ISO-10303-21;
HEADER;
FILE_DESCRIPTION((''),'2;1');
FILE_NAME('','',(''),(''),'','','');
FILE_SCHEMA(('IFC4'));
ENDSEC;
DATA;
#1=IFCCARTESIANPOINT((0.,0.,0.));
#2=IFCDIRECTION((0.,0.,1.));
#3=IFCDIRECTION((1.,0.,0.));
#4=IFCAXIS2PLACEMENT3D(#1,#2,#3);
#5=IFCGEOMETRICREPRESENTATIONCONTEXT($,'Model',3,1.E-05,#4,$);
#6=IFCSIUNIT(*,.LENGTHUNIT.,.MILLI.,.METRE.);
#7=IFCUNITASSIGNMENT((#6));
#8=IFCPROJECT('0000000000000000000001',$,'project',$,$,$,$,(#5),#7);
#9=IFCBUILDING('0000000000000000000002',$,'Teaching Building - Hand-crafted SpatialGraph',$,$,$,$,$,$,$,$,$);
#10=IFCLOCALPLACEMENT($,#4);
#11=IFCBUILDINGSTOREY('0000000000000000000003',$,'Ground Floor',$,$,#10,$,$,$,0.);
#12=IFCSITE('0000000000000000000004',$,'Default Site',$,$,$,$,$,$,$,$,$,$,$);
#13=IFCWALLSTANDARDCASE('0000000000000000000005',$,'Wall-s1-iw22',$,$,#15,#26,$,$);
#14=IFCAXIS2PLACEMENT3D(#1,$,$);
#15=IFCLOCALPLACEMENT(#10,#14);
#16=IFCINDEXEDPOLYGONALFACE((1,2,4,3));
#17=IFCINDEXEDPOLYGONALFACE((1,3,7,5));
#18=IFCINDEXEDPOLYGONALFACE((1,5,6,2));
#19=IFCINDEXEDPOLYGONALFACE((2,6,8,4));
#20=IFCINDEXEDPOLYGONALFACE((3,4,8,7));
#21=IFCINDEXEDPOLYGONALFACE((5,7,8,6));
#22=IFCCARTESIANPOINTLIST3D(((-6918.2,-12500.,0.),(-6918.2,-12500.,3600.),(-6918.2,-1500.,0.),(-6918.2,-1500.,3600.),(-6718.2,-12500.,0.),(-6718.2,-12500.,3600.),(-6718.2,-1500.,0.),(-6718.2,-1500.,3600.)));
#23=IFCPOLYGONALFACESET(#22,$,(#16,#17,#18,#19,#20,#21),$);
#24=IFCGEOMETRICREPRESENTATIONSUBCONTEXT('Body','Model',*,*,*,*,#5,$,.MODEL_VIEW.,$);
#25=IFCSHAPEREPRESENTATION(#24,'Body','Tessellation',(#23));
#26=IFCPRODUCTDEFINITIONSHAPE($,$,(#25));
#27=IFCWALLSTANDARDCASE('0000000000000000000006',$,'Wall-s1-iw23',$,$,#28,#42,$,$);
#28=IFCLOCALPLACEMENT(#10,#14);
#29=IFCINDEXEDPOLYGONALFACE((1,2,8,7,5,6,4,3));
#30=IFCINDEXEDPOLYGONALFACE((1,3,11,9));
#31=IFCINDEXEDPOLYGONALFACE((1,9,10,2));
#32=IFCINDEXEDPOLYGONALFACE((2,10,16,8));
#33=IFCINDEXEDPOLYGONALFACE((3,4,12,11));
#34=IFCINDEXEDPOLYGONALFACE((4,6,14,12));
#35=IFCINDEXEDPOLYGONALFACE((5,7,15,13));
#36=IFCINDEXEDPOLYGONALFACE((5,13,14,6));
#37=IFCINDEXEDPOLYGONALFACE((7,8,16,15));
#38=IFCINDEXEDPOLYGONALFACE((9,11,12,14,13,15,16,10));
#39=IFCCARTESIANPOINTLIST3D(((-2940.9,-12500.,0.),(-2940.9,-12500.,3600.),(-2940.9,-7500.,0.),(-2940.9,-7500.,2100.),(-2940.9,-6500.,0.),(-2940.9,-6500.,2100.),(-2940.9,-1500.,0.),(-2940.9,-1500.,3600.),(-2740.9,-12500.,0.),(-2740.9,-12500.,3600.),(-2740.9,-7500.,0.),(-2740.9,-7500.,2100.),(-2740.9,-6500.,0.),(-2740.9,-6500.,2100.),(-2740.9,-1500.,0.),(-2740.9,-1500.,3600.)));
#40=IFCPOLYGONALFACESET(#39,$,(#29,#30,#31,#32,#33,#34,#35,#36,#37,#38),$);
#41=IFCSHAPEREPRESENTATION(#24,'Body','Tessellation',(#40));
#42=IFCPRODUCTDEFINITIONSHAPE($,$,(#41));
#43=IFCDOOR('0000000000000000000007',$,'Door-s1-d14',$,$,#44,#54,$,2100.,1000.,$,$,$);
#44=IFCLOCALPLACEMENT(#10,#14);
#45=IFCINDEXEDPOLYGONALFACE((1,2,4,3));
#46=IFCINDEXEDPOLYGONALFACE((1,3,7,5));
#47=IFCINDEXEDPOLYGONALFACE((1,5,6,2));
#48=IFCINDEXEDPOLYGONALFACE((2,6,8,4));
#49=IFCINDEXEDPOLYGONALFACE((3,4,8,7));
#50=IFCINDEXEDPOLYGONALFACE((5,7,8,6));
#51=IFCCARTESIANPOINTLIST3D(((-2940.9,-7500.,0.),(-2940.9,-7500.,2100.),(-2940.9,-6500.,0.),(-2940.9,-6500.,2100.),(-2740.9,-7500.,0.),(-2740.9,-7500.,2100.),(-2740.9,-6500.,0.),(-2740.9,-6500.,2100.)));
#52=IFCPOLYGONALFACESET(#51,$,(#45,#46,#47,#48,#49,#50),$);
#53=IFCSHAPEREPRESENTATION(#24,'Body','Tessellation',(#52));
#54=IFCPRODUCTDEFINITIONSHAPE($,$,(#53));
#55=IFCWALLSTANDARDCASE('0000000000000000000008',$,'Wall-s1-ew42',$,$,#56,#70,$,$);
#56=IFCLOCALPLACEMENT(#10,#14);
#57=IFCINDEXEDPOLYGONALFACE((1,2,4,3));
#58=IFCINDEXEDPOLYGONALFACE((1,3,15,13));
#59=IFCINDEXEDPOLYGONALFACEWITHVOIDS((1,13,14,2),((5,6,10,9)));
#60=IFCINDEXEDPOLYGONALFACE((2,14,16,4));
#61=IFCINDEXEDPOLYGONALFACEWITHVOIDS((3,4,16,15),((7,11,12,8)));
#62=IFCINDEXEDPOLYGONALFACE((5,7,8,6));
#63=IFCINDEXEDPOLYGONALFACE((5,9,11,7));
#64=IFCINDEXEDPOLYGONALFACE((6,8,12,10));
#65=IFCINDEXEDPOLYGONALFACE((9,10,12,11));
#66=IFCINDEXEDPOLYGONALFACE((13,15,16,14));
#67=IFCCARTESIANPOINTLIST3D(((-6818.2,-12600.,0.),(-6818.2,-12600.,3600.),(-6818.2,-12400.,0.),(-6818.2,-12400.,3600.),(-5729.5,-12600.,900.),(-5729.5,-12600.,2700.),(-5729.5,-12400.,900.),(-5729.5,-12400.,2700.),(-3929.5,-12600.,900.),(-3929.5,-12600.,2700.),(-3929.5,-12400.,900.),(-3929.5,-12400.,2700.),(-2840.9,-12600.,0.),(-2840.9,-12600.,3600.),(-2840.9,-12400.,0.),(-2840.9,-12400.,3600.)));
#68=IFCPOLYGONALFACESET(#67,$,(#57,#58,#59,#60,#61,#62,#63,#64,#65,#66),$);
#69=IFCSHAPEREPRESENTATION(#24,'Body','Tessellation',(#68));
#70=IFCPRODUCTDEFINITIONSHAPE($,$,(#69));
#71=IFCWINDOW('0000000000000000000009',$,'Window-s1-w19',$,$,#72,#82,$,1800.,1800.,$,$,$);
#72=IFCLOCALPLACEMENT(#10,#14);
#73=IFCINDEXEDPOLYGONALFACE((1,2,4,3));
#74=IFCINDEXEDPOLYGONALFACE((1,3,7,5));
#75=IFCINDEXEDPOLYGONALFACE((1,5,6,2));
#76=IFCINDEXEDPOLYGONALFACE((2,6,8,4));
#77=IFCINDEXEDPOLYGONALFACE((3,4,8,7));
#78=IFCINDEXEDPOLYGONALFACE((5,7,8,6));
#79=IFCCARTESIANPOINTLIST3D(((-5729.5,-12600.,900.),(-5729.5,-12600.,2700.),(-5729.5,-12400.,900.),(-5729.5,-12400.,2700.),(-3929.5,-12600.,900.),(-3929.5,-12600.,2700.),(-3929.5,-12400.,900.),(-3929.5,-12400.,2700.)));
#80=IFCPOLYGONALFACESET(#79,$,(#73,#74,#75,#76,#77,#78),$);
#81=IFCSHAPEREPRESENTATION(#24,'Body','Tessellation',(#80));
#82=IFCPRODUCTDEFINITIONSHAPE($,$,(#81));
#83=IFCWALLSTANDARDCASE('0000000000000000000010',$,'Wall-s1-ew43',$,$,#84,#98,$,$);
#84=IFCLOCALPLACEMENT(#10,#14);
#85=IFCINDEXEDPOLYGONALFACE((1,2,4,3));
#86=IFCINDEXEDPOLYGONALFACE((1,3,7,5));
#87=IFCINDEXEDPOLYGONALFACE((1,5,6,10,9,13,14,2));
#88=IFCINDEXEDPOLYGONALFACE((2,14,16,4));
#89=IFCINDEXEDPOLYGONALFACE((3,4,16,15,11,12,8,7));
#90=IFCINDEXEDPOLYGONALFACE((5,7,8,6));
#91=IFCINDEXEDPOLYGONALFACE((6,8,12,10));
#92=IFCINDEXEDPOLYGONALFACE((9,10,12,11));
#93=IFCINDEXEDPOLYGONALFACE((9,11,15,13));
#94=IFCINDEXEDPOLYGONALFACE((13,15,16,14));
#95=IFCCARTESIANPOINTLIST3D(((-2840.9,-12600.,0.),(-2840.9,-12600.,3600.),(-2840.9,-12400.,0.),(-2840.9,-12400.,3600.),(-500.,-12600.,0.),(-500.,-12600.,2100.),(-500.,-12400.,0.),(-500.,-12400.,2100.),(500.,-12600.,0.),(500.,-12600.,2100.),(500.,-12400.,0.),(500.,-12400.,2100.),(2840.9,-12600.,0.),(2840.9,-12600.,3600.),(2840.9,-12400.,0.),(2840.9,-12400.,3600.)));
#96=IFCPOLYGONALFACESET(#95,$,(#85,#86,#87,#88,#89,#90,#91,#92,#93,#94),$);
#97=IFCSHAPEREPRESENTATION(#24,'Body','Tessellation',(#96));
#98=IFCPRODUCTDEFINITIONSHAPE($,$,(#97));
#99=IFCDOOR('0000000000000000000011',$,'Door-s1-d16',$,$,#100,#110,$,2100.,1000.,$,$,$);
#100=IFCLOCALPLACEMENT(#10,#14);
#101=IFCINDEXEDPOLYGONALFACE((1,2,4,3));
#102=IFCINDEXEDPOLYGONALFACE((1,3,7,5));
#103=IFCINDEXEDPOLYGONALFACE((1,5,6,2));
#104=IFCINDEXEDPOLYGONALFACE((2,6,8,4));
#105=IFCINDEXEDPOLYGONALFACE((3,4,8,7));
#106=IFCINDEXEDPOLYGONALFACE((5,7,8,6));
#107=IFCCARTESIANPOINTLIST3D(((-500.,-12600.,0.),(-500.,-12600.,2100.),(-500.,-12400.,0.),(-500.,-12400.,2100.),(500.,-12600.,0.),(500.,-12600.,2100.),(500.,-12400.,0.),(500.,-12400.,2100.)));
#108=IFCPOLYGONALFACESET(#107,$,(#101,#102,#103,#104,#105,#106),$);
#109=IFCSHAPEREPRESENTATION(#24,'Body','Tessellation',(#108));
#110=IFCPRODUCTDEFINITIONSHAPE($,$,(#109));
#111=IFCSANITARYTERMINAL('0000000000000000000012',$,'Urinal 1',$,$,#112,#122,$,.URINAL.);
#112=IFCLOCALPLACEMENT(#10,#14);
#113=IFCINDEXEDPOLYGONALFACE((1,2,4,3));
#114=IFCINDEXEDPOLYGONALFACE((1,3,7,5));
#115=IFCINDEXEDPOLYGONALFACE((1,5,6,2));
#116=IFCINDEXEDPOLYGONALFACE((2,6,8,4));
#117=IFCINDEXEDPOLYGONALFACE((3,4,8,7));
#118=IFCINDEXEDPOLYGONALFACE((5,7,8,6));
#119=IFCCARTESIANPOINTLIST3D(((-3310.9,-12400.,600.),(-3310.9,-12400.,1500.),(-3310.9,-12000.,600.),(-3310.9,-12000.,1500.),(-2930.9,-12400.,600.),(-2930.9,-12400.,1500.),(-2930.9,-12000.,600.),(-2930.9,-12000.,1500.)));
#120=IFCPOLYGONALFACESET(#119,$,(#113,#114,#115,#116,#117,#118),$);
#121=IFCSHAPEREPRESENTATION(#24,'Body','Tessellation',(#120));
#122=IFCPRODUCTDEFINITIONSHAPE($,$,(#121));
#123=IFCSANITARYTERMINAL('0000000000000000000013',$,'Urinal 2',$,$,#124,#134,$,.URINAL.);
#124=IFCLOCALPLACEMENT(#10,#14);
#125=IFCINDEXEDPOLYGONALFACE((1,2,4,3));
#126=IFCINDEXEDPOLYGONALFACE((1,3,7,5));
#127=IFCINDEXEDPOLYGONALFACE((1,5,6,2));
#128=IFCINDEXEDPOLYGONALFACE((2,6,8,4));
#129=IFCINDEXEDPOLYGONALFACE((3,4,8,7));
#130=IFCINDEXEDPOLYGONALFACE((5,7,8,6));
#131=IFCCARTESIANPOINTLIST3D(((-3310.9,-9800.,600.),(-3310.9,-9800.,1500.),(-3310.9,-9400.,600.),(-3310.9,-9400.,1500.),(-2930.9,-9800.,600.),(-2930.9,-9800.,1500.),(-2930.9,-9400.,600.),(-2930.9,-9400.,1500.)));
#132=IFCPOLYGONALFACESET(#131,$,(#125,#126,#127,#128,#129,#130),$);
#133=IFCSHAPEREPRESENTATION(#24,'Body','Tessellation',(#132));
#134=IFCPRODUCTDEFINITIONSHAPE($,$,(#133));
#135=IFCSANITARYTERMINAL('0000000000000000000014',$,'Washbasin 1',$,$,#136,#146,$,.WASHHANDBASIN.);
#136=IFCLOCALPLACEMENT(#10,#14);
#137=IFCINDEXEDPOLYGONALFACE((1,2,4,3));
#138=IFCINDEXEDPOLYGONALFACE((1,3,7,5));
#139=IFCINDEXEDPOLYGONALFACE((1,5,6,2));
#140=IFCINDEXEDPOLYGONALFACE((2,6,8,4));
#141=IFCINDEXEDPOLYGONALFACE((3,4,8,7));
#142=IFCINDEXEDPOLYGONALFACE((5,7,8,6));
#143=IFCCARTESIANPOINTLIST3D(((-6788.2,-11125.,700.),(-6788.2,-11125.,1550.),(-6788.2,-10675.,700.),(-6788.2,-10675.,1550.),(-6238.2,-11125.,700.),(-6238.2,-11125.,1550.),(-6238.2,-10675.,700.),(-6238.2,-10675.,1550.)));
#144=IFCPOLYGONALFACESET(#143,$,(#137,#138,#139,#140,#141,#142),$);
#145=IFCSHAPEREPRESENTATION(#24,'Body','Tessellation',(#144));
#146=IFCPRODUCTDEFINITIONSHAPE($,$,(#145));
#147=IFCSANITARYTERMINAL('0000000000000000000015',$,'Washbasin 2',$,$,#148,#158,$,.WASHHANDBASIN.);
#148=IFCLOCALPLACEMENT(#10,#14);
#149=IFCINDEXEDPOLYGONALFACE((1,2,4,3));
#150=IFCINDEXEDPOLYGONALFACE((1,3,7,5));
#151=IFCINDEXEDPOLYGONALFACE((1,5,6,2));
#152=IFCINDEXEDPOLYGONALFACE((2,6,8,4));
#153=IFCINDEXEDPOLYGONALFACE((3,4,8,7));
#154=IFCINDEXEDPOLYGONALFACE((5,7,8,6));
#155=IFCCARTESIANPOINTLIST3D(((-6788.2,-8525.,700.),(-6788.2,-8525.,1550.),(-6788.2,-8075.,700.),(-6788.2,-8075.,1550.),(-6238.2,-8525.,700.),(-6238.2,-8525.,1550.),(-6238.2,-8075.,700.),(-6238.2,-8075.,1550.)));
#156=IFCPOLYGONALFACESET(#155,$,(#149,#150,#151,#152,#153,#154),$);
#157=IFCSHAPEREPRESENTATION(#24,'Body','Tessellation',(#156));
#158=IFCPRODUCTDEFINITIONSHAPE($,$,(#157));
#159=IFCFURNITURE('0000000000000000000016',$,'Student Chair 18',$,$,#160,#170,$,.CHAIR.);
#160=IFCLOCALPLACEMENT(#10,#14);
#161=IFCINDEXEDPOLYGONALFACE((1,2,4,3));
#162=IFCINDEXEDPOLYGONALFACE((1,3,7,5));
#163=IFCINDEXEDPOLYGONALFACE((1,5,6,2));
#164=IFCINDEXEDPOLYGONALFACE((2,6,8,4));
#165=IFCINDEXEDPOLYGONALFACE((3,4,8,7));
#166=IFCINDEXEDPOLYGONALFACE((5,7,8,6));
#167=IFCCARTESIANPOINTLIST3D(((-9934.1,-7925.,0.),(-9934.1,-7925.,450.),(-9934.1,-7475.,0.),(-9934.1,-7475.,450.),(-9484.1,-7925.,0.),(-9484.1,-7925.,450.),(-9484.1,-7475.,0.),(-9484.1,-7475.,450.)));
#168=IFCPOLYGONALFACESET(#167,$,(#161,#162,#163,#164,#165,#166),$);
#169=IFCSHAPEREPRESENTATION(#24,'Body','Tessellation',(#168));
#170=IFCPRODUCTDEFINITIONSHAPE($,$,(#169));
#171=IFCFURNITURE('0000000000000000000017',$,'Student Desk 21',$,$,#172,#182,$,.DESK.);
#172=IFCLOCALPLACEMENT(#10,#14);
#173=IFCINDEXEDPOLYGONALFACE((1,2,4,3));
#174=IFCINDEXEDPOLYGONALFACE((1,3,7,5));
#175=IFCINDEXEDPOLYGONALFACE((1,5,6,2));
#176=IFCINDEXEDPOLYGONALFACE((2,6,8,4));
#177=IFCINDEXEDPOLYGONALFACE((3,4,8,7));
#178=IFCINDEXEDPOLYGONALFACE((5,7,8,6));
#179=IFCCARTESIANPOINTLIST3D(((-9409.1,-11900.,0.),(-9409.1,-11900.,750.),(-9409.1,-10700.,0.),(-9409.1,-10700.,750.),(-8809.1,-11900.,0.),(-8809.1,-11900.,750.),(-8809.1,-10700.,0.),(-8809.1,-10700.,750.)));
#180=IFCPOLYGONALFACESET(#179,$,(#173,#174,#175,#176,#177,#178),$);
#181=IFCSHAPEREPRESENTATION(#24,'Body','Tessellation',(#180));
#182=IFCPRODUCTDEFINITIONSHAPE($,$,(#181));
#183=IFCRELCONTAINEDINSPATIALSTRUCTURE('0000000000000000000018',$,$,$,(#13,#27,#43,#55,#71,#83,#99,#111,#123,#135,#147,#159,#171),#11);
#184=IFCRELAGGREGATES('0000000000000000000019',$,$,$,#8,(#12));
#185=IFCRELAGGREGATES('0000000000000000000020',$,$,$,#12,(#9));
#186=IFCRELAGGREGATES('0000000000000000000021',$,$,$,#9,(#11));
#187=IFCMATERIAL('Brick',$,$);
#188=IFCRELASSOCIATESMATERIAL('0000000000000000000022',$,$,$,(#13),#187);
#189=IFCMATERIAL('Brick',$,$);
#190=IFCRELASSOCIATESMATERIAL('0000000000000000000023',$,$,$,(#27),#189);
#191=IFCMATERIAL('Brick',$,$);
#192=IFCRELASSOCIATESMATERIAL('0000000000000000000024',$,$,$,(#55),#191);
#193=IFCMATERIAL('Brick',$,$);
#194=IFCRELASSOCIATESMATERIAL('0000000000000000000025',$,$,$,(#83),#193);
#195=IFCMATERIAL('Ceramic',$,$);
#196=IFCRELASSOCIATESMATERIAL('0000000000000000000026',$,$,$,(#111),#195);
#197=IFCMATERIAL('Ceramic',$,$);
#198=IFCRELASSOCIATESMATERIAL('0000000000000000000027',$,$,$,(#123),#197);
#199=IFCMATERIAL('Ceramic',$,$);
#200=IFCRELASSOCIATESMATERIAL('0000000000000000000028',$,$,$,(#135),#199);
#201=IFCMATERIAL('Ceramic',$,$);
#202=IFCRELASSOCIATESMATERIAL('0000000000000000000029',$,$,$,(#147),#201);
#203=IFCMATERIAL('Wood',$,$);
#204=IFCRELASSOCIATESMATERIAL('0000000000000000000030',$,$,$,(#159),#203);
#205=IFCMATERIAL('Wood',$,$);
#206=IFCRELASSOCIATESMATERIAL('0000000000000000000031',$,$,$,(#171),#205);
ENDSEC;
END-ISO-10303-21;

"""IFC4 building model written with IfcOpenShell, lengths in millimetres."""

from ifc_helpers import new_model, si_unit, frame, frame_2d, origin_with_axes, origin_2d, place, context, subcontext, project, spatial, rectangle, extrude, material, element, fill, save


model = new_model("IFC4")

# Units and contexts
model_context = context("Model", 3, precision=1e-05, world=origin_with_axes())
body_context = subcontext(model_context, "Body", "Model", "MODEL_VIEW")
ifc_project = project(units=[si_unit("LENGTHUNIT", "METRE", prefix="MILLI")], contexts=[model_context])

# Site, building, storey
site = spatial("IfcSite", under=ifc_project, Name="Default Site")
building = spatial("IfcBuilding", under=site, Name="Teaching Building - Hand-crafted SpatialGraph")
storey_placement = place(None, origin_with_axes())
storey = spatial("IfcBuildingStorey", under=building, at=storey_placement, Name="Ground Floor", Elevation=0.0)

# Wall
ifc_material_1 = material(Name="Brick")
wall_1_placement = place(storey_placement, frame((-6818.2, -12500.0, 0.0), z_axis=(0.0, 0.0, 1.0), x_axis=(0.0, 1.0, 0.0)))
element("IfcWallStandardCase", 1, at=wall_1_placement, inside=storey, material=ifc_material_1, Name="Wall-s1-iw22", context=body_context, shape_type="SweptSolid", body=[
    extrude(rectangle(XDim=11000.0, YDim=200.0, at=frame_2d((5500.0, 0.0))), origin_with_axes(), (0.0, 0.0, 1.0), 3600.0),
])

# Wall, opening, door
ifc_material_2 = material(Name="Brick")
wall_2_placement = place(storey_placement, frame((-2840.9, -12500.0, 0.0), z_axis=(0.0, 0.0, 1.0), x_axis=(0.0, 1.0, 0.0)))
wall_2 = element("IfcWallStandardCase", 2, at=wall_2_placement, inside=storey, material=ifc_material_2, Name="Wall-s1-iw23", context=body_context, shape_type="SweptSolid", body=[
    extrude(rectangle(XDim=11000.0, YDim=200.0, at=frame_2d((5500.0, 0.0))), origin_with_axes(), (0.0, 0.0, 1.0), 3600.0),
])
opening_1_placement = place(wall_2_placement, frame((5000.0, 0.0, 0.0), z_axis=(0.0, 0.0, 1.0), x_axis=(1.0, 0.0, 0.0)))
opening_1 = element("IfcOpeningElement", 3, at=opening_1_placement, cuts=wall_2, context=body_context, shape_type="SweptSolid", body=[
    extrude(rectangle(XDim=1000.0, YDim=400.0, at=frame_2d((500.0, 0.0))), origin_with_axes(), (0.0, 0.0, 1.0), 2100.0),
])
door_1_placement = place(storey_placement, frame((-2840.9, -7500.0, 0.0), z_axis=(0.0, 0.0, 1.0), x_axis=(0.0, 1.0, 0.0)))
door_1 = element("IfcDoor", 4, at=door_1_placement, inside=storey, Name="Door-s1-d14", OverallHeight=2100.0, OverallWidth=1000.0, context=body_context, shape_type="SweptSolid", body=[
    extrude(rectangle(XDim=1000.0, YDim=200.0, at=frame_2d((500.0, 0.0))), origin_with_axes(), (0.0, 0.0, 1.0), 2100.0),
])
fill(opening_1, door_1)

# Wall, opening, window
ifc_material_3 = material(Name="Brick")
wall_3_placement = place(storey_placement, frame((-6818.2, -12500.0, 0.0), z_axis=(0.0, 0.0, 1.0), x_axis=(1.0, 0.0, 0.0)))
wall_3 = element("IfcWallStandardCase", 5, at=wall_3_placement, inside=storey, material=ifc_material_3, Name="Wall-s1-ew42", context=body_context, shape_type="SweptSolid", body=[
    extrude(rectangle(XDim=3977.3, YDim=200.0, at=frame_2d((1988.6, 0.0))), origin_with_axes(), (0.0, 0.0, 1.0), 3600.0),
])
opening_2_placement = place(wall_3_placement, frame((1088.6, 0.0, 900.0), z_axis=(0.0, 0.0, 1.0), x_axis=(1.0, 0.0, 0.0)))
opening_2 = element("IfcOpeningElement", 6, at=opening_2_placement, cuts=wall_3, context=body_context, shape_type="SweptSolid", body=[
    extrude(rectangle(XDim=1800.0, YDim=400.0, at=frame_2d((900.0, 0.0))), origin_with_axes(), (0.0, 0.0, 1.0), 1800.0),
])
window_placement = place(storey_placement, frame((-5729.5, -12500.0, 900.0), z_axis=(0.0, 0.0, 1.0), x_axis=(1.0, 0.0, 0.0)))
window = element("IfcWindow", 7, at=window_placement, inside=storey, Name="Window-s1-w19", OverallHeight=1800.0, OverallWidth=1800.0, context=body_context, shape_type="SweptSolid", body=[
    extrude(rectangle(XDim=1800.0, YDim=200.0, at=frame_2d((900.0, 0.0))), origin_with_axes(), (0.0, 0.0, 1.0), 1800.0),
])
fill(opening_2, window)

# Wall, opening, door
ifc_material_4 = material(Name="Brick")
wall_4_placement = place(storey_placement, frame((-2840.9, -12500.0, 0.0), z_axis=(0.0, 0.0, 1.0), x_axis=(1.0, 0.0, 0.0)))
wall_4 = element("IfcWallStandardCase", 8, at=wall_4_placement, inside=storey, material=ifc_material_4, Name="Wall-s1-ew43", context=body_context, shape_type="SweptSolid", body=[
    extrude(rectangle(XDim=5681.8, YDim=200.0, at=frame_2d((2840.9, 0.0))), origin_with_axes(), (0.0, 0.0, 1.0), 3600.0),
])
opening_3_placement = place(wall_4_placement, frame((2340.9, 0.0, 0.0), z_axis=(0.0, 0.0, 1.0), x_axis=(1.0, 0.0, 0.0)))
opening_3 = element("IfcOpeningElement", 9, at=opening_3_placement, cuts=wall_4, context=body_context, shape_type="SweptSolid", body=[
    extrude(rectangle(XDim=1000.0, YDim=400.0, at=frame_2d((500.0, 0.0))), origin_with_axes(), (0.0, 0.0, 1.0), 2100.0),
])
door_2_placement = place(storey_placement, frame((-500.0, -12500.0, 0.0), z_axis=(0.0, 0.0, 1.0), x_axis=(1.0, 0.0, 0.0)))
door_2 = element("IfcDoor", 10, at=door_2_placement, inside=storey, Name="Door-s1-d16", OverallHeight=2100.0, OverallWidth=1000.0, context=body_context, shape_type="SweptSolid", body=[
    extrude(rectangle(XDim=1000.0, YDim=200.0, at=frame_2d((500.0, 0.0))), origin_with_axes(), (0.0, 0.0, 1.0), 2100.0),
])
fill(opening_3, door_2)

# Sanitary terminals
ifc_material_5 = material(Name="Ceramic")
sanitary_terminal_1_placement = place(storey_placement, frame((-3120.9, -12200.0, 600.0), z_axis=(0.0, 0.0, 1.0), x_axis=(0.0, 1.0, 0.0)))
element("IfcSanitaryTerminal", 11, at=sanitary_terminal_1_placement, inside=storey, material=ifc_material_5, Name="Urinal 1", PredefinedType="URINAL", context=body_context, shape_type="SweptSolid", body=[
    extrude(rectangle(XDim=400.0, YDim=380.0, at=origin_2d()), origin_with_axes(), (0.0, 0.0, 1.0), 900.0),
])
ifc_material_6 = material(Name="Ceramic")
sanitary_terminal_2_placement = place(storey_placement, frame((-3120.9, -9600.0, 600.0), z_axis=(0.0, 0.0, 1.0), x_axis=(0.0, 1.0, 0.0)))
element("IfcSanitaryTerminal", 12, at=sanitary_terminal_2_placement, inside=storey, material=ifc_material_6, Name="Urinal 2", PredefinedType="URINAL", context=body_context, shape_type="SweptSolid", body=[
    extrude(rectangle(XDim=400.0, YDim=380.0, at=origin_2d()), origin_with_axes(), (0.0, 0.0, 1.0), 900.0),
])
ifc_material_7 = material(Name="Ceramic")
sanitary_terminal_3_placement = place(storey_placement, frame((-6513.2, -10900.0, 700.0), z_axis=(0.0, 0.0, 1.0), x_axis=(0.0, 1.0, 0.0)))
element("IfcSanitaryTerminal", 13, at=sanitary_terminal_3_placement, inside=storey, material=ifc_material_7, Name="Washbasin 1", PredefinedType="WASHHANDBASIN", context=body_context, shape_type="SweptSolid", body=[
    extrude(rectangle(XDim=450.0, YDim=550.0, at=origin_2d()), origin_with_axes(), (0.0, 0.0, 1.0), 850.0),
])
ifc_material_8 = material(Name="Ceramic")
sanitary_terminal_4_placement = place(storey_placement, frame((-6513.2, -8300.0, 700.0), z_axis=(0.0, 0.0, 1.0), x_axis=(0.0, 1.0, 0.0)))
element("IfcSanitaryTerminal", 14, at=sanitary_terminal_4_placement, inside=storey, material=ifc_material_8, Name="Washbasin 2", PredefinedType="WASHHANDBASIN", context=body_context, shape_type="SweptSolid", body=[
    extrude(rectangle(XDim=450.0, YDim=550.0, at=origin_2d()), origin_with_axes(), (0.0, 0.0, 1.0), 850.0),
])

# Furniture
ifc_material_9 = material(Name="Wood")
furniture_1_placement = place(storey_placement, frame((-9709.1, -7700.0, 0.0), z_axis=(0.0, 0.0, 1.0), x_axis=(1.0, 0.0, 0.0)))
element("IfcFurniture", 15, at=furniture_1_placement, inside=storey, material=ifc_material_9, Name="Student Chair 18", PredefinedType="CHAIR", context=body_context, shape_type="SweptSolid", body=[
    extrude(rectangle(XDim=450.0, YDim=450.0, at=origin_2d()), origin_with_axes(), (0.0, 0.0, 1.0), 450.0),
])
ifc_material_10 = material(Name="Wood")
furniture_2_placement = place(storey_placement, frame((-9109.1, -11300.0, 0.0), z_axis=(0.0, 0.0, 1.0), x_axis=(0.0, 1.0, 0.0)))
element("IfcFurniture", 16, at=furniture_2_placement, inside=storey, material=ifc_material_10, Name="Student Desk 21", PredefinedType="DESK", context=body_context, shape_type="SweptSolid", body=[
    extrude(rectangle(XDim=1200.0, YDim=600.0, at=origin_2d()), origin_with_axes(), (0.0, 0.0, 1.0), 750.0),
])

save(model, "model.ifc")
